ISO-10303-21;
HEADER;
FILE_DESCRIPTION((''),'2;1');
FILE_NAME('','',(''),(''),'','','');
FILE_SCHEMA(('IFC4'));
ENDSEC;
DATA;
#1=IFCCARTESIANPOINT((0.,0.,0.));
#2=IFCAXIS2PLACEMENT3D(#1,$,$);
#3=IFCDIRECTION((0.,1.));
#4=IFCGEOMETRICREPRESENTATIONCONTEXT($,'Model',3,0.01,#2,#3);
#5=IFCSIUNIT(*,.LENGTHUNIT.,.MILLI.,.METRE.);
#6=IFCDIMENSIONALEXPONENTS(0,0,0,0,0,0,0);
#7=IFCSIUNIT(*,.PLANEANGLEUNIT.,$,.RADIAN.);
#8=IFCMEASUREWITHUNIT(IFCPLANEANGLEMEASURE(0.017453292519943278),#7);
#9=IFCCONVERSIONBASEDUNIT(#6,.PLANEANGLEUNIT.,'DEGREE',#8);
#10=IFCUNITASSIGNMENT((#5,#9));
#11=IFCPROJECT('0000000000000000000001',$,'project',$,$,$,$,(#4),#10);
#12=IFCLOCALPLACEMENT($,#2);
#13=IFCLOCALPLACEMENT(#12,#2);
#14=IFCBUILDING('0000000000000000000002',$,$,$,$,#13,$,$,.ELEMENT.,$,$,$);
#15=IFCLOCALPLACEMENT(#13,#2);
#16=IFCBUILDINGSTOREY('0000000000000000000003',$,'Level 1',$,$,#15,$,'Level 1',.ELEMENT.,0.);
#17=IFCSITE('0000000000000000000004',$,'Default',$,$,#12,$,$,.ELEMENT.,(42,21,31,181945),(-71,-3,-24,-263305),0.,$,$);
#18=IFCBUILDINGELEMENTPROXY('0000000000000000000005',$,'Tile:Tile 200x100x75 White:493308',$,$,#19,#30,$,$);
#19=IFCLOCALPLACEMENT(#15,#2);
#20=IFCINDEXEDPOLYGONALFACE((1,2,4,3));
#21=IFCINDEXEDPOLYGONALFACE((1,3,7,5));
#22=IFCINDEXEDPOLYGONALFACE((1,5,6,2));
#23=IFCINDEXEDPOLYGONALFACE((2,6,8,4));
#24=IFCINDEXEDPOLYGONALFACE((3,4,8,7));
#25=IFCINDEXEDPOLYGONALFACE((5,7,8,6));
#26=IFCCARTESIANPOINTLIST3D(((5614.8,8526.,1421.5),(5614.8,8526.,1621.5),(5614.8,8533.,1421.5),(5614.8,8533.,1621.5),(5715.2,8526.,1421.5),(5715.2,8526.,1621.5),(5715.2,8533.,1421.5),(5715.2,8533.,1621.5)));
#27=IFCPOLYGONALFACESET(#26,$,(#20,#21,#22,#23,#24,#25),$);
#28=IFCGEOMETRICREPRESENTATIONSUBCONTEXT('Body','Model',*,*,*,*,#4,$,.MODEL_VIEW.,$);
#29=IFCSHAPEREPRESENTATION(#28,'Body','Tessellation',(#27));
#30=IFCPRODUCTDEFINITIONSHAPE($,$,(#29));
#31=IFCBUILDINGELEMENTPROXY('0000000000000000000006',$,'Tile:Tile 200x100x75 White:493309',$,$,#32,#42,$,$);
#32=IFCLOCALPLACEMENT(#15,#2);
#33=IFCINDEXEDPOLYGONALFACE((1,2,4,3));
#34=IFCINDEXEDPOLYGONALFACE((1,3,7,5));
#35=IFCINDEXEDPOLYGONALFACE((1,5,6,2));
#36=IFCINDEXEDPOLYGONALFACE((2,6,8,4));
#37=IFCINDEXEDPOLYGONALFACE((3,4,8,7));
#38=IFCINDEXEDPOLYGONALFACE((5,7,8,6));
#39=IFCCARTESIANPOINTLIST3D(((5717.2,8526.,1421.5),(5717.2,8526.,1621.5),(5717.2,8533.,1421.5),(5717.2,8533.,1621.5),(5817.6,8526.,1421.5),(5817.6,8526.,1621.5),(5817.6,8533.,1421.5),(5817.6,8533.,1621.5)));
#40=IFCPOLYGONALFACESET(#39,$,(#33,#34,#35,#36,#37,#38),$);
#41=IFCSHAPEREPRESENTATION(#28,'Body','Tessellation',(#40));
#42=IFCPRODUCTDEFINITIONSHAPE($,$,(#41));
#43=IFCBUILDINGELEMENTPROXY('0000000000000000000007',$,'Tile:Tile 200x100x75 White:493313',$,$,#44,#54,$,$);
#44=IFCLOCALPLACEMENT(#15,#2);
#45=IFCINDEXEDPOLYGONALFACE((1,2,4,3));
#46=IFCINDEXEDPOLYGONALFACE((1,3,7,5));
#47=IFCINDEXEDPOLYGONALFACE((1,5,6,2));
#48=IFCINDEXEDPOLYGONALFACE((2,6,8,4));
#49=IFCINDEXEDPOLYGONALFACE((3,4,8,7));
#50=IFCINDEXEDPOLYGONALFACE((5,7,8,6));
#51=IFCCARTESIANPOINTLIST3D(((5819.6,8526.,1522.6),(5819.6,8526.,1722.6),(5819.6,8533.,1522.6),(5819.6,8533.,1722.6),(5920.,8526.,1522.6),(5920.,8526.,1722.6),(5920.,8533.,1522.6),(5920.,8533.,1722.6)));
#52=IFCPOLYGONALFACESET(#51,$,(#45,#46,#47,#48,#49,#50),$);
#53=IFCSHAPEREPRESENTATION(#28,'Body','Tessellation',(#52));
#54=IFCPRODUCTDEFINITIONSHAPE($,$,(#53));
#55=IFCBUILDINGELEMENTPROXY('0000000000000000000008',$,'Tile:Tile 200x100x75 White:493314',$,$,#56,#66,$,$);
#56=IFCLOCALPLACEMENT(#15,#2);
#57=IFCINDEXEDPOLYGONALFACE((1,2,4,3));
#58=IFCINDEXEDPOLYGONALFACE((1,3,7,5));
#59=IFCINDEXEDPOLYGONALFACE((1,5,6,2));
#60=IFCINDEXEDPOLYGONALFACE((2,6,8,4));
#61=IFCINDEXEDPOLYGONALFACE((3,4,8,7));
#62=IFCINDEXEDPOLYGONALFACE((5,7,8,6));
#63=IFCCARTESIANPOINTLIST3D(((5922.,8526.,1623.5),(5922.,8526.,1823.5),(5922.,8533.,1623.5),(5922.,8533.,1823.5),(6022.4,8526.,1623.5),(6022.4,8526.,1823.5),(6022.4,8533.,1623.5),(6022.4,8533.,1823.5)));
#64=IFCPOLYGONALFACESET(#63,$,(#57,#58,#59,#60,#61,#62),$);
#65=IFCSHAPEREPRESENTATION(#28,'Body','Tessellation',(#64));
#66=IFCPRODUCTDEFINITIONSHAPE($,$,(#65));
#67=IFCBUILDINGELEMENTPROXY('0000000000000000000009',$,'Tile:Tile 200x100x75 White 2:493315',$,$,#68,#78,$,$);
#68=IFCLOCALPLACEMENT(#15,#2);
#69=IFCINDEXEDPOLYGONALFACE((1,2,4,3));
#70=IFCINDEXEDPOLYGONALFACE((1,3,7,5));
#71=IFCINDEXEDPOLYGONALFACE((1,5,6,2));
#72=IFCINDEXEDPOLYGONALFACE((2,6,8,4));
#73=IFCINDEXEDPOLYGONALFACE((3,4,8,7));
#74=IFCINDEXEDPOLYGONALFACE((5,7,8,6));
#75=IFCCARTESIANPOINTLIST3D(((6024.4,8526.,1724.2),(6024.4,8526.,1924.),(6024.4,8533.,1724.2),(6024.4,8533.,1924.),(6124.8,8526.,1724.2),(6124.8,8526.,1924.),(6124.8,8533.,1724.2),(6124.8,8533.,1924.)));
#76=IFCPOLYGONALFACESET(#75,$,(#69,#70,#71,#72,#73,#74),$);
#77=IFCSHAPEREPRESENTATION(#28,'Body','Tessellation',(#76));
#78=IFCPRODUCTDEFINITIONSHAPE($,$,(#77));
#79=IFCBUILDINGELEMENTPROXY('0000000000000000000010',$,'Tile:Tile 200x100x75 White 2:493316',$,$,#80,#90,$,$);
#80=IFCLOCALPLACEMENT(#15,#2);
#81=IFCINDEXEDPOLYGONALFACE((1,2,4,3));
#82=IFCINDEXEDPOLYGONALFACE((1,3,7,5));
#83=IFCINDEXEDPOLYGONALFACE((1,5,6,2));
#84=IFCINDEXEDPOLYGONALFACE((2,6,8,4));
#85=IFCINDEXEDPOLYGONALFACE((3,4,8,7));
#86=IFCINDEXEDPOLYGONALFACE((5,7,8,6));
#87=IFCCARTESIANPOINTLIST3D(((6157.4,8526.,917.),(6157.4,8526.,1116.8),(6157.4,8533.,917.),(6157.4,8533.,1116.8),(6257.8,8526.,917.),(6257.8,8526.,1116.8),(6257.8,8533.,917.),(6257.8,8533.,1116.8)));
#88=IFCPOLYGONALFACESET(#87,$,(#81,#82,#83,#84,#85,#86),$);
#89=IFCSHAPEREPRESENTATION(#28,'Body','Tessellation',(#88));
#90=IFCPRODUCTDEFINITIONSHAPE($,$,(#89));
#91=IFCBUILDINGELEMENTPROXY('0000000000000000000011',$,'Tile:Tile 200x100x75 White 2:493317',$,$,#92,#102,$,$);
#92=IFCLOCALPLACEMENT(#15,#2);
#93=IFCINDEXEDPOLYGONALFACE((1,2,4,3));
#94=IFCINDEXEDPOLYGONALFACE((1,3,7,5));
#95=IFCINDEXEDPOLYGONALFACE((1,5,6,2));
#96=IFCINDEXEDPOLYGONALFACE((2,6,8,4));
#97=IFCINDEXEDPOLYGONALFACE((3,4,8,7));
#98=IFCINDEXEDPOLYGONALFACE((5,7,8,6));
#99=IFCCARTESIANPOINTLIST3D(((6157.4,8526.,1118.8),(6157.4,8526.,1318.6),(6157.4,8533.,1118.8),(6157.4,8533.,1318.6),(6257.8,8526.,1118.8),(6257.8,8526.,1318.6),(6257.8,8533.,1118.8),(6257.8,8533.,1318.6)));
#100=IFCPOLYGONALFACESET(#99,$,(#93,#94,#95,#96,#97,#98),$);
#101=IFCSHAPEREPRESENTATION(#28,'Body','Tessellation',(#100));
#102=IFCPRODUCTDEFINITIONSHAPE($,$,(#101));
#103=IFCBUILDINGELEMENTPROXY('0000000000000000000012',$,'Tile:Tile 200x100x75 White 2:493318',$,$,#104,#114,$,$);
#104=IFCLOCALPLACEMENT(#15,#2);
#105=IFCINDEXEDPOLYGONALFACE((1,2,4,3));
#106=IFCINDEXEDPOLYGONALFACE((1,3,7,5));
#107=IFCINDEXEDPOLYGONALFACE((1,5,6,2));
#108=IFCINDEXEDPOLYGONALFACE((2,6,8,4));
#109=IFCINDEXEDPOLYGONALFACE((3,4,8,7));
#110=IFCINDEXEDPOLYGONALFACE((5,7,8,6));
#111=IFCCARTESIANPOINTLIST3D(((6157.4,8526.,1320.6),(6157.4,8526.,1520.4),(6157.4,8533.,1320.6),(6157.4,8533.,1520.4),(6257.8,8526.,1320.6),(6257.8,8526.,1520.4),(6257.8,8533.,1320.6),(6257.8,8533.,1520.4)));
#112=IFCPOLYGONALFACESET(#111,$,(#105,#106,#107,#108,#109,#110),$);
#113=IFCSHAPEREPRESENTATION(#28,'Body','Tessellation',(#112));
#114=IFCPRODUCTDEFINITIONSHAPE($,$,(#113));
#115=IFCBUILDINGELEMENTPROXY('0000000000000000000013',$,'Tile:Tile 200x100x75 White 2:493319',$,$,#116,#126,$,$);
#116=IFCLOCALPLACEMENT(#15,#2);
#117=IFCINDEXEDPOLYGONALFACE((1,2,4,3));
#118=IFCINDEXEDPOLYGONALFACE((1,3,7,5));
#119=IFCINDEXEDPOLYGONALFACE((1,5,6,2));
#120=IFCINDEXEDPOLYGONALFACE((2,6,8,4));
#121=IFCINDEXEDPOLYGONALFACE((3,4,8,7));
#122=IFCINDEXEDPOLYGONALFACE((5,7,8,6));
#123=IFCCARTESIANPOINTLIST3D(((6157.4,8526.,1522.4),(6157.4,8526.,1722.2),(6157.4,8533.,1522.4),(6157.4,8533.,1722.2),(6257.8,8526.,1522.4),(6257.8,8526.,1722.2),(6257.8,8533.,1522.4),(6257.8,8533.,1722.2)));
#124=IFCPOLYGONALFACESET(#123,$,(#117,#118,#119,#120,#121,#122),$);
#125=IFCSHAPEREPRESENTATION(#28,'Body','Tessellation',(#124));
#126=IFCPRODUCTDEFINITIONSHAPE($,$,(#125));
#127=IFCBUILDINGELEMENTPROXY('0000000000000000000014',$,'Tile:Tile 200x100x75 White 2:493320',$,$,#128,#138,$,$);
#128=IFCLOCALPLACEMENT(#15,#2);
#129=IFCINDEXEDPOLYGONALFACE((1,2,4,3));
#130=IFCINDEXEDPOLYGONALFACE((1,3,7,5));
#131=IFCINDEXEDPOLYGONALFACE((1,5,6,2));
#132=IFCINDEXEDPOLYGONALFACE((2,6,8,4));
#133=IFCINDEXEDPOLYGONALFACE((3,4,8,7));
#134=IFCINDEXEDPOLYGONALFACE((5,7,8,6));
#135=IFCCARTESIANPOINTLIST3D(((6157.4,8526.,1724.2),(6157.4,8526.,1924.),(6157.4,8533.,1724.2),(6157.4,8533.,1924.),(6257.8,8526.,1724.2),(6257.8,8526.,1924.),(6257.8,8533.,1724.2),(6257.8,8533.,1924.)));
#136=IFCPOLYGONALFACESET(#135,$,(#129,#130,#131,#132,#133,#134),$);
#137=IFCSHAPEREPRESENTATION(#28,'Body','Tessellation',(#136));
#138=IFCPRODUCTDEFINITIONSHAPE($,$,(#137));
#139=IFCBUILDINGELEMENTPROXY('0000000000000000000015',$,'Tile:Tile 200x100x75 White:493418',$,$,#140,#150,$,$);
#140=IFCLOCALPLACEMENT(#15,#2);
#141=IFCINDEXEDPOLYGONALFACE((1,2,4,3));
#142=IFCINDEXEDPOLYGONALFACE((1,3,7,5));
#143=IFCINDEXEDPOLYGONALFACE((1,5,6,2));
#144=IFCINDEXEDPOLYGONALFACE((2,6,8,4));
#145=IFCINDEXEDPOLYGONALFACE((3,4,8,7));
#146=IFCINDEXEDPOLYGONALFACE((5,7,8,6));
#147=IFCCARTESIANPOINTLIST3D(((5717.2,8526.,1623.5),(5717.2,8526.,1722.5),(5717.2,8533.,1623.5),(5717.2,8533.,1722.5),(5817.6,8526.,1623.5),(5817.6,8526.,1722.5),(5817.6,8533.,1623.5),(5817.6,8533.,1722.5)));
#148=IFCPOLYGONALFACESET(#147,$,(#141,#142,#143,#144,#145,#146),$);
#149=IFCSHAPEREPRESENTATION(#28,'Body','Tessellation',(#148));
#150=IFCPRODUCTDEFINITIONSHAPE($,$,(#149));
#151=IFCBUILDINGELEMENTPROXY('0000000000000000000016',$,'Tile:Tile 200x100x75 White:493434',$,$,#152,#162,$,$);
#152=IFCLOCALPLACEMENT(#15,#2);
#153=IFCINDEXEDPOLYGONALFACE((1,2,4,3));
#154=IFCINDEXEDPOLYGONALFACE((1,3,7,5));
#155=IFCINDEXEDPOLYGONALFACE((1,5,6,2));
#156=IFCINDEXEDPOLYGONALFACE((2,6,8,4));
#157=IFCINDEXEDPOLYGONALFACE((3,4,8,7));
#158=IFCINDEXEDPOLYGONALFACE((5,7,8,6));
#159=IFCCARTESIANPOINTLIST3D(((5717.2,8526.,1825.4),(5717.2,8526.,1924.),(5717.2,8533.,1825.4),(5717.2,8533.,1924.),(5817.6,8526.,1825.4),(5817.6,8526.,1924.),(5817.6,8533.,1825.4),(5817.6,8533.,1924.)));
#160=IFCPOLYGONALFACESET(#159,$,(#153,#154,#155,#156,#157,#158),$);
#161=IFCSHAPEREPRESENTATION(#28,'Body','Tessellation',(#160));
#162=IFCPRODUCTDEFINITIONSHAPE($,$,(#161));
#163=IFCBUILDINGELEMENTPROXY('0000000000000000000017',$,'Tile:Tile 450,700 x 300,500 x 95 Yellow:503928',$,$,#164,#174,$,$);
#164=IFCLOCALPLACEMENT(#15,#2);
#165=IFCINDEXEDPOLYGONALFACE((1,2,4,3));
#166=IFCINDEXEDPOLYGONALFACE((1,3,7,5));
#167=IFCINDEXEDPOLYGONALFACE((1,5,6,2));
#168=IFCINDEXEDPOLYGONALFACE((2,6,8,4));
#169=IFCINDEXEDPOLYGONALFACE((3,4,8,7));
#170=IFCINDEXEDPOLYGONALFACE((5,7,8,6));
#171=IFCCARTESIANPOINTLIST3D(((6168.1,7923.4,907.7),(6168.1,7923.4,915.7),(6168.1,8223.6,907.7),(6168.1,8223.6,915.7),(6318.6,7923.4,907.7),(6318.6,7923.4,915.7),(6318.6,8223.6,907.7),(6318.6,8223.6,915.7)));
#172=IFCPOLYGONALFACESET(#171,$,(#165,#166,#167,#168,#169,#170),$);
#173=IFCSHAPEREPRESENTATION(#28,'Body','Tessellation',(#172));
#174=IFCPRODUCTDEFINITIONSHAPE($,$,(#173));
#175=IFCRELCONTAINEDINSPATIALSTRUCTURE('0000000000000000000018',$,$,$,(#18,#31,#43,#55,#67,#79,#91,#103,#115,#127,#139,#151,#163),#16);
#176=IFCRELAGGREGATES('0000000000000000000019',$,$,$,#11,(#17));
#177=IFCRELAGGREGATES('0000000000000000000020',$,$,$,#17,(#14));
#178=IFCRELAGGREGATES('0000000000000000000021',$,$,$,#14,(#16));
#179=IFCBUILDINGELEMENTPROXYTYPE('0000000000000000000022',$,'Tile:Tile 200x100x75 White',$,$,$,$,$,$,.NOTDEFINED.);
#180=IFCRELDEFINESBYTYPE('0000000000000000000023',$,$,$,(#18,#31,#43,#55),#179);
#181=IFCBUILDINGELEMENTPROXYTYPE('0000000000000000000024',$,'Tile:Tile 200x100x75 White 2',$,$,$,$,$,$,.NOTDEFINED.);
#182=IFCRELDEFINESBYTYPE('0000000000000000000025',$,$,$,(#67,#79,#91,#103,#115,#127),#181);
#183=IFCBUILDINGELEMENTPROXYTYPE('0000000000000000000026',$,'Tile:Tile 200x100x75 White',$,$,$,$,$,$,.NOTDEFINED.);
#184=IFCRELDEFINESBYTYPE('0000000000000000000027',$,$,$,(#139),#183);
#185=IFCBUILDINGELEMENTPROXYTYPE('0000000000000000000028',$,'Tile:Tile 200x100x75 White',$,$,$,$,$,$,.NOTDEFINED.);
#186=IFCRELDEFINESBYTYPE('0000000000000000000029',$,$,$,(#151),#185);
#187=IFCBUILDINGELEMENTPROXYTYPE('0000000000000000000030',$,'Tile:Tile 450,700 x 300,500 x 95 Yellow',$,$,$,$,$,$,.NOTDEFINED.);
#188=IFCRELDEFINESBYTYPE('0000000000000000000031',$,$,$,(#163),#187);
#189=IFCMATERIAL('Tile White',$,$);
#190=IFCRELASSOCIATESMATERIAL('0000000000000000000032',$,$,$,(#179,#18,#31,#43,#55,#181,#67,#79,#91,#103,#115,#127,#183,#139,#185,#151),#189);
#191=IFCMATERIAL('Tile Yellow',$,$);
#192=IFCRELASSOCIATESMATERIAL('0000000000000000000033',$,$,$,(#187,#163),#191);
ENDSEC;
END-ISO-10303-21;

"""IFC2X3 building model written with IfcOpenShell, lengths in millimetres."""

from ifc_helpers import new_model, entity, si_unit, converted_unit, direction, frame, frame_2d, origin, origin_2d_with_axis, place, context, subcontext, project, spatial, rectangle, extrude, source, transform, mapped, material, type_object, type_shapes, element, save


model = new_model("IFC2X3")

# Units and contexts
model_context = context("Model", 3, precision=0.01, world=origin(), true_north=direction((0.0, 1.0)))
body_context = subcontext(model_context, "Body", "Model", "MODEL_VIEW")
ifc_project = project(units=[si_unit("LENGTHUNIT", "METRE", prefix="MILLI"), converted_unit("PLANEANGLEUNIT", "DEGREE", entity("IfcPlaneAngleMeasure", 0.017453292519943278), si_unit("PLANEANGLEUNIT", "RADIAN"), dimensions=[0, 0, 0, 0, 0, 0, 0])], contexts=[model_context])

# Site, building, storey
site_placement = place(None, origin())
site = spatial("IfcSite", under=ifc_project, at=site_placement, Name="Default", CompositionType="ELEMENT", RefLatitude=(42, 21, 31, 181945), RefLongitude=(-71, -3, -24, -263305), RefElevation=0.0)
building_placement = place(site_placement, origin())
building = spatial("IfcBuilding", under=site, at=building_placement, CompositionType="ELEMENT")
storey_placement = place(building_placement, origin())
storey = spatial("IfcBuildingStorey", under=building, at=storey_placement, Name="Level 1", LongName="Level 1", CompositionType="ELEMENT", Elevation=0.0)

# Building element proxies
ifc_material_1 = material(Name="Tile Yellow")
ifc_material_2 = material(Name="Tile White")
building_element_proxy_type_1 = type_object("IfcBuildingElementProxyType", Name="Tile:Tile 200x100x75 White", PredefinedType="NOTDEFINED", material=ifc_material_2)
shared_shape_1 = source(origin(), body_context, "Body", "SweptSolid", [
    extrude(rectangle(XDim=200.0, YDim=100.4, at=frame_2d((0.0, 0.0), x_axis=(1.0, 0.0))), frame((-50.2, -100.0, 0.0), z_axis=(0.0, 0.0, 1.0), x_axis=(0.0, -1.0, 0.0)), (0.0, 0.0, 1.0), 7.0),
])
type_shapes(building_element_proxy_type_1, [shared_shape_1])
for number, where, z_axis, x_axis, name in (
    (1, (5715.2, 8533.0, 1621.5), (0.0, -1.0, 0.0), (1.0, 0.0, 0.0), "Tile:Tile 200x100x75 White:493308"),
    (2, (5817.6, 8533.0, 1621.5), (0.0, -1.0, 0.0), (1.0, 0.0, 0.0), "Tile:Tile 200x100x75 White:493309"),
    (3, (5819.6, 8533.0, 1522.6), (0.0, -1.0, 0.0), (-1.0, 0.0, 0.0), "Tile:Tile 200x100x75 White:493313"),
    (4, (5922.0, 8533.0, 1623.5), (0.0, -1.0, 0.0), (-1.0, 0.0, 0.0), "Tile:Tile 200x100x75 White:493314"),
):
    element("IfcBuildingElementProxy", number, at=place(storey_placement, frame(where, z_axis=z_axis, x_axis=x_axis)), inside=storey, type_object=building_element_proxy_type_1, material=ifc_material_2, Name=name, context=body_context, shape_type="MappedRepresentation", body=[
        mapped(shared_shape_1, transform((0.0, 0.0, 0.0), scale=1.0)),
    ])
building_element_proxy_type_2 = type_object("IfcBuildingElementProxyType", Name="Tile:Tile 200x100x75 White 2", PredefinedType="NOTDEFINED", material=ifc_material_2)
shared_shape_2 = source(origin(), body_context, "Body", "SweptSolid", [
    extrude(rectangle(XDim=199.8, YDim=100.4, at=frame_2d((0.0, 0.0), x_axis=(1.0, 0.0))), frame((-50.2, -99.9, 0.0), z_axis=(0.0, 0.0, 1.0), x_axis=(0.0, -1.0, 0.0)), (0.0, 0.0, 1.0), 7.0),
])
type_shapes(building_element_proxy_type_2, [shared_shape_2])
for number, where, z_axis, x_axis, name in (
    (5, (6024.4, 8533.0, 1724.2), (0.0, -1.0, 0.0), (-1.0, 0.0, 0.0), "Tile:Tile 200x100x75 White 2:493315"),
    (6, (6257.8, 8533.0, 1116.8), (0.0, -1.0, 0.0), (1.0, 0.0, 0.0), "Tile:Tile 200x100x75 White 2:493316"),
    (7, (6257.8, 8533.0, 1318.6), (0.0, -1.0, 0.0), (1.0, 0.0, 0.0), "Tile:Tile 200x100x75 White 2:493317"),
    (8, (6257.8, 8533.0, 1520.4), (0.0, -1.0, 0.0), (1.0, 0.0, 0.0), "Tile:Tile 200x100x75 White 2:493318"),
    (9, (6257.8, 8533.0, 1722.2), (0.0, -1.0, 0.0), (1.0, 0.0, 0.0), "Tile:Tile 200x100x75 White 2:493319"),
    (10, (6257.8, 8533.0, 1924.0), (0.0, -1.0, 0.0), (1.0, 0.0, 0.0), "Tile:Tile 200x100x75 White 2:493320"),
):
    element("IfcBuildingElementProxy", number, at=place(storey_placement, frame(where, z_axis=z_axis, x_axis=x_axis)), inside=storey, type_object=building_element_proxy_type_2, material=ifc_material_2, Name=name, context=body_context, shape_type="MappedRepresentation", body=[
        mapped(shared_shape_2, transform((0.0, 0.0, 0.0), scale=1.0)),
    ])
building_element_proxy_type_3 = type_object("IfcBuildingElementProxyType", Name="Tile:Tile 200x100x75 White", PredefinedType="NOTDEFINED", material=ifc_material_2)
shared_shape_3 = source(origin(), body_context, "Body", "SweptSolid", [
    extrude(rectangle(XDim=99.0, YDim=100.4, at=origin_2d_with_axis()), frame((-50.2, -49.5, 0.0), z_axis=(0.0, 0.0, 1.0), x_axis=(0.0, -1.0, 0.0)), (0.0, 0.0, 1.0), 7.0),
])
type_shapes(building_element_proxy_type_3, [shared_shape_3])
proxy_1_placement = place(storey_placement, frame((5817.6, 8533.0, 1722.5), z_axis=(0.0, -1.0, 0.0), x_axis=(1.0, 0.0, 0.0)))
element("IfcBuildingElementProxy", 11, at=proxy_1_placement, inside=storey, type_object=building_element_proxy_type_3, material=ifc_material_2, Name="Tile:Tile 200x100x75 White:493418", context=body_context, shape_type="MappedRepresentation", body=[
    mapped(shared_shape_3, transform((0.0, 0.0, 0.0), scale=1.0)),
])
building_element_proxy_type_4 = type_object("IfcBuildingElementProxyType", Name="Tile:Tile 200x100x75 White", PredefinedType="NOTDEFINED", material=ifc_material_2)
shared_shape_4 = source(origin(), body_context, "Body", "SweptSolid", [
    extrude(rectangle(XDim=98.6, YDim=100.4, at=origin_2d_with_axis()), frame((-50.2, -49.3, 0.0), z_axis=(0.0, 0.0, 1.0), x_axis=(0.0, -1.0, 0.0)), (0.0, 0.0, 1.0), 7.0),
])
type_shapes(building_element_proxy_type_4, [shared_shape_4])
proxy_2_placement = place(storey_placement, frame((5817.6, 8533.0, 1924.0), z_axis=(0.0, -1.0, 0.0), x_axis=(1.0, 0.0, 0.0)))
element("IfcBuildingElementProxy", 12, at=proxy_2_placement, inside=storey, type_object=building_element_proxy_type_4, material=ifc_material_2, Name="Tile:Tile 200x100x75 White:493434", context=body_context, shape_type="MappedRepresentation", body=[
    mapped(shared_shape_4, transform((0.0, 0.0, 0.0), scale=1.0)),
])
building_element_proxy_type_5 = type_object("IfcBuildingElementProxyType", Name="Tile:Tile 450,700 x 300,500 x 95 Yellow", PredefinedType="NOTDEFINED", material=ifc_material_1)
shared_shape_5 = source(origin(), body_context, "Body", "SweptSolid", [
    extrude(rectangle(XDim=150.5, YDim=300.2, at=frame_2d((0.0, 0.0), x_axis=(1.0, 0.0))), frame((-75.2, -150.1, 0.0), z_axis=(0.0, 0.0, 1.0), x_axis=(-1.0, 0.0, 0.0)), (0.0, 0.0, 1.0), 8.0),
])
type_shapes(building_element_proxy_type_5, [shared_shape_5])
proxy_3_placement = place(storey_placement, frame((6318.6, 8223.6, 907.7)))
element("IfcBuildingElementProxy", 13, at=proxy_3_placement, inside=storey, type_object=building_element_proxy_type_5, material=ifc_material_1, Name="Tile:Tile 450,700 x 300,500 x 95 Yellow:503928", context=body_context, shape_type="MappedRepresentation", body=[
    mapped(shared_shape_5, transform((0.0, 0.0, 0.0), scale=1.0)),
])

save(model, "model.ifc")
